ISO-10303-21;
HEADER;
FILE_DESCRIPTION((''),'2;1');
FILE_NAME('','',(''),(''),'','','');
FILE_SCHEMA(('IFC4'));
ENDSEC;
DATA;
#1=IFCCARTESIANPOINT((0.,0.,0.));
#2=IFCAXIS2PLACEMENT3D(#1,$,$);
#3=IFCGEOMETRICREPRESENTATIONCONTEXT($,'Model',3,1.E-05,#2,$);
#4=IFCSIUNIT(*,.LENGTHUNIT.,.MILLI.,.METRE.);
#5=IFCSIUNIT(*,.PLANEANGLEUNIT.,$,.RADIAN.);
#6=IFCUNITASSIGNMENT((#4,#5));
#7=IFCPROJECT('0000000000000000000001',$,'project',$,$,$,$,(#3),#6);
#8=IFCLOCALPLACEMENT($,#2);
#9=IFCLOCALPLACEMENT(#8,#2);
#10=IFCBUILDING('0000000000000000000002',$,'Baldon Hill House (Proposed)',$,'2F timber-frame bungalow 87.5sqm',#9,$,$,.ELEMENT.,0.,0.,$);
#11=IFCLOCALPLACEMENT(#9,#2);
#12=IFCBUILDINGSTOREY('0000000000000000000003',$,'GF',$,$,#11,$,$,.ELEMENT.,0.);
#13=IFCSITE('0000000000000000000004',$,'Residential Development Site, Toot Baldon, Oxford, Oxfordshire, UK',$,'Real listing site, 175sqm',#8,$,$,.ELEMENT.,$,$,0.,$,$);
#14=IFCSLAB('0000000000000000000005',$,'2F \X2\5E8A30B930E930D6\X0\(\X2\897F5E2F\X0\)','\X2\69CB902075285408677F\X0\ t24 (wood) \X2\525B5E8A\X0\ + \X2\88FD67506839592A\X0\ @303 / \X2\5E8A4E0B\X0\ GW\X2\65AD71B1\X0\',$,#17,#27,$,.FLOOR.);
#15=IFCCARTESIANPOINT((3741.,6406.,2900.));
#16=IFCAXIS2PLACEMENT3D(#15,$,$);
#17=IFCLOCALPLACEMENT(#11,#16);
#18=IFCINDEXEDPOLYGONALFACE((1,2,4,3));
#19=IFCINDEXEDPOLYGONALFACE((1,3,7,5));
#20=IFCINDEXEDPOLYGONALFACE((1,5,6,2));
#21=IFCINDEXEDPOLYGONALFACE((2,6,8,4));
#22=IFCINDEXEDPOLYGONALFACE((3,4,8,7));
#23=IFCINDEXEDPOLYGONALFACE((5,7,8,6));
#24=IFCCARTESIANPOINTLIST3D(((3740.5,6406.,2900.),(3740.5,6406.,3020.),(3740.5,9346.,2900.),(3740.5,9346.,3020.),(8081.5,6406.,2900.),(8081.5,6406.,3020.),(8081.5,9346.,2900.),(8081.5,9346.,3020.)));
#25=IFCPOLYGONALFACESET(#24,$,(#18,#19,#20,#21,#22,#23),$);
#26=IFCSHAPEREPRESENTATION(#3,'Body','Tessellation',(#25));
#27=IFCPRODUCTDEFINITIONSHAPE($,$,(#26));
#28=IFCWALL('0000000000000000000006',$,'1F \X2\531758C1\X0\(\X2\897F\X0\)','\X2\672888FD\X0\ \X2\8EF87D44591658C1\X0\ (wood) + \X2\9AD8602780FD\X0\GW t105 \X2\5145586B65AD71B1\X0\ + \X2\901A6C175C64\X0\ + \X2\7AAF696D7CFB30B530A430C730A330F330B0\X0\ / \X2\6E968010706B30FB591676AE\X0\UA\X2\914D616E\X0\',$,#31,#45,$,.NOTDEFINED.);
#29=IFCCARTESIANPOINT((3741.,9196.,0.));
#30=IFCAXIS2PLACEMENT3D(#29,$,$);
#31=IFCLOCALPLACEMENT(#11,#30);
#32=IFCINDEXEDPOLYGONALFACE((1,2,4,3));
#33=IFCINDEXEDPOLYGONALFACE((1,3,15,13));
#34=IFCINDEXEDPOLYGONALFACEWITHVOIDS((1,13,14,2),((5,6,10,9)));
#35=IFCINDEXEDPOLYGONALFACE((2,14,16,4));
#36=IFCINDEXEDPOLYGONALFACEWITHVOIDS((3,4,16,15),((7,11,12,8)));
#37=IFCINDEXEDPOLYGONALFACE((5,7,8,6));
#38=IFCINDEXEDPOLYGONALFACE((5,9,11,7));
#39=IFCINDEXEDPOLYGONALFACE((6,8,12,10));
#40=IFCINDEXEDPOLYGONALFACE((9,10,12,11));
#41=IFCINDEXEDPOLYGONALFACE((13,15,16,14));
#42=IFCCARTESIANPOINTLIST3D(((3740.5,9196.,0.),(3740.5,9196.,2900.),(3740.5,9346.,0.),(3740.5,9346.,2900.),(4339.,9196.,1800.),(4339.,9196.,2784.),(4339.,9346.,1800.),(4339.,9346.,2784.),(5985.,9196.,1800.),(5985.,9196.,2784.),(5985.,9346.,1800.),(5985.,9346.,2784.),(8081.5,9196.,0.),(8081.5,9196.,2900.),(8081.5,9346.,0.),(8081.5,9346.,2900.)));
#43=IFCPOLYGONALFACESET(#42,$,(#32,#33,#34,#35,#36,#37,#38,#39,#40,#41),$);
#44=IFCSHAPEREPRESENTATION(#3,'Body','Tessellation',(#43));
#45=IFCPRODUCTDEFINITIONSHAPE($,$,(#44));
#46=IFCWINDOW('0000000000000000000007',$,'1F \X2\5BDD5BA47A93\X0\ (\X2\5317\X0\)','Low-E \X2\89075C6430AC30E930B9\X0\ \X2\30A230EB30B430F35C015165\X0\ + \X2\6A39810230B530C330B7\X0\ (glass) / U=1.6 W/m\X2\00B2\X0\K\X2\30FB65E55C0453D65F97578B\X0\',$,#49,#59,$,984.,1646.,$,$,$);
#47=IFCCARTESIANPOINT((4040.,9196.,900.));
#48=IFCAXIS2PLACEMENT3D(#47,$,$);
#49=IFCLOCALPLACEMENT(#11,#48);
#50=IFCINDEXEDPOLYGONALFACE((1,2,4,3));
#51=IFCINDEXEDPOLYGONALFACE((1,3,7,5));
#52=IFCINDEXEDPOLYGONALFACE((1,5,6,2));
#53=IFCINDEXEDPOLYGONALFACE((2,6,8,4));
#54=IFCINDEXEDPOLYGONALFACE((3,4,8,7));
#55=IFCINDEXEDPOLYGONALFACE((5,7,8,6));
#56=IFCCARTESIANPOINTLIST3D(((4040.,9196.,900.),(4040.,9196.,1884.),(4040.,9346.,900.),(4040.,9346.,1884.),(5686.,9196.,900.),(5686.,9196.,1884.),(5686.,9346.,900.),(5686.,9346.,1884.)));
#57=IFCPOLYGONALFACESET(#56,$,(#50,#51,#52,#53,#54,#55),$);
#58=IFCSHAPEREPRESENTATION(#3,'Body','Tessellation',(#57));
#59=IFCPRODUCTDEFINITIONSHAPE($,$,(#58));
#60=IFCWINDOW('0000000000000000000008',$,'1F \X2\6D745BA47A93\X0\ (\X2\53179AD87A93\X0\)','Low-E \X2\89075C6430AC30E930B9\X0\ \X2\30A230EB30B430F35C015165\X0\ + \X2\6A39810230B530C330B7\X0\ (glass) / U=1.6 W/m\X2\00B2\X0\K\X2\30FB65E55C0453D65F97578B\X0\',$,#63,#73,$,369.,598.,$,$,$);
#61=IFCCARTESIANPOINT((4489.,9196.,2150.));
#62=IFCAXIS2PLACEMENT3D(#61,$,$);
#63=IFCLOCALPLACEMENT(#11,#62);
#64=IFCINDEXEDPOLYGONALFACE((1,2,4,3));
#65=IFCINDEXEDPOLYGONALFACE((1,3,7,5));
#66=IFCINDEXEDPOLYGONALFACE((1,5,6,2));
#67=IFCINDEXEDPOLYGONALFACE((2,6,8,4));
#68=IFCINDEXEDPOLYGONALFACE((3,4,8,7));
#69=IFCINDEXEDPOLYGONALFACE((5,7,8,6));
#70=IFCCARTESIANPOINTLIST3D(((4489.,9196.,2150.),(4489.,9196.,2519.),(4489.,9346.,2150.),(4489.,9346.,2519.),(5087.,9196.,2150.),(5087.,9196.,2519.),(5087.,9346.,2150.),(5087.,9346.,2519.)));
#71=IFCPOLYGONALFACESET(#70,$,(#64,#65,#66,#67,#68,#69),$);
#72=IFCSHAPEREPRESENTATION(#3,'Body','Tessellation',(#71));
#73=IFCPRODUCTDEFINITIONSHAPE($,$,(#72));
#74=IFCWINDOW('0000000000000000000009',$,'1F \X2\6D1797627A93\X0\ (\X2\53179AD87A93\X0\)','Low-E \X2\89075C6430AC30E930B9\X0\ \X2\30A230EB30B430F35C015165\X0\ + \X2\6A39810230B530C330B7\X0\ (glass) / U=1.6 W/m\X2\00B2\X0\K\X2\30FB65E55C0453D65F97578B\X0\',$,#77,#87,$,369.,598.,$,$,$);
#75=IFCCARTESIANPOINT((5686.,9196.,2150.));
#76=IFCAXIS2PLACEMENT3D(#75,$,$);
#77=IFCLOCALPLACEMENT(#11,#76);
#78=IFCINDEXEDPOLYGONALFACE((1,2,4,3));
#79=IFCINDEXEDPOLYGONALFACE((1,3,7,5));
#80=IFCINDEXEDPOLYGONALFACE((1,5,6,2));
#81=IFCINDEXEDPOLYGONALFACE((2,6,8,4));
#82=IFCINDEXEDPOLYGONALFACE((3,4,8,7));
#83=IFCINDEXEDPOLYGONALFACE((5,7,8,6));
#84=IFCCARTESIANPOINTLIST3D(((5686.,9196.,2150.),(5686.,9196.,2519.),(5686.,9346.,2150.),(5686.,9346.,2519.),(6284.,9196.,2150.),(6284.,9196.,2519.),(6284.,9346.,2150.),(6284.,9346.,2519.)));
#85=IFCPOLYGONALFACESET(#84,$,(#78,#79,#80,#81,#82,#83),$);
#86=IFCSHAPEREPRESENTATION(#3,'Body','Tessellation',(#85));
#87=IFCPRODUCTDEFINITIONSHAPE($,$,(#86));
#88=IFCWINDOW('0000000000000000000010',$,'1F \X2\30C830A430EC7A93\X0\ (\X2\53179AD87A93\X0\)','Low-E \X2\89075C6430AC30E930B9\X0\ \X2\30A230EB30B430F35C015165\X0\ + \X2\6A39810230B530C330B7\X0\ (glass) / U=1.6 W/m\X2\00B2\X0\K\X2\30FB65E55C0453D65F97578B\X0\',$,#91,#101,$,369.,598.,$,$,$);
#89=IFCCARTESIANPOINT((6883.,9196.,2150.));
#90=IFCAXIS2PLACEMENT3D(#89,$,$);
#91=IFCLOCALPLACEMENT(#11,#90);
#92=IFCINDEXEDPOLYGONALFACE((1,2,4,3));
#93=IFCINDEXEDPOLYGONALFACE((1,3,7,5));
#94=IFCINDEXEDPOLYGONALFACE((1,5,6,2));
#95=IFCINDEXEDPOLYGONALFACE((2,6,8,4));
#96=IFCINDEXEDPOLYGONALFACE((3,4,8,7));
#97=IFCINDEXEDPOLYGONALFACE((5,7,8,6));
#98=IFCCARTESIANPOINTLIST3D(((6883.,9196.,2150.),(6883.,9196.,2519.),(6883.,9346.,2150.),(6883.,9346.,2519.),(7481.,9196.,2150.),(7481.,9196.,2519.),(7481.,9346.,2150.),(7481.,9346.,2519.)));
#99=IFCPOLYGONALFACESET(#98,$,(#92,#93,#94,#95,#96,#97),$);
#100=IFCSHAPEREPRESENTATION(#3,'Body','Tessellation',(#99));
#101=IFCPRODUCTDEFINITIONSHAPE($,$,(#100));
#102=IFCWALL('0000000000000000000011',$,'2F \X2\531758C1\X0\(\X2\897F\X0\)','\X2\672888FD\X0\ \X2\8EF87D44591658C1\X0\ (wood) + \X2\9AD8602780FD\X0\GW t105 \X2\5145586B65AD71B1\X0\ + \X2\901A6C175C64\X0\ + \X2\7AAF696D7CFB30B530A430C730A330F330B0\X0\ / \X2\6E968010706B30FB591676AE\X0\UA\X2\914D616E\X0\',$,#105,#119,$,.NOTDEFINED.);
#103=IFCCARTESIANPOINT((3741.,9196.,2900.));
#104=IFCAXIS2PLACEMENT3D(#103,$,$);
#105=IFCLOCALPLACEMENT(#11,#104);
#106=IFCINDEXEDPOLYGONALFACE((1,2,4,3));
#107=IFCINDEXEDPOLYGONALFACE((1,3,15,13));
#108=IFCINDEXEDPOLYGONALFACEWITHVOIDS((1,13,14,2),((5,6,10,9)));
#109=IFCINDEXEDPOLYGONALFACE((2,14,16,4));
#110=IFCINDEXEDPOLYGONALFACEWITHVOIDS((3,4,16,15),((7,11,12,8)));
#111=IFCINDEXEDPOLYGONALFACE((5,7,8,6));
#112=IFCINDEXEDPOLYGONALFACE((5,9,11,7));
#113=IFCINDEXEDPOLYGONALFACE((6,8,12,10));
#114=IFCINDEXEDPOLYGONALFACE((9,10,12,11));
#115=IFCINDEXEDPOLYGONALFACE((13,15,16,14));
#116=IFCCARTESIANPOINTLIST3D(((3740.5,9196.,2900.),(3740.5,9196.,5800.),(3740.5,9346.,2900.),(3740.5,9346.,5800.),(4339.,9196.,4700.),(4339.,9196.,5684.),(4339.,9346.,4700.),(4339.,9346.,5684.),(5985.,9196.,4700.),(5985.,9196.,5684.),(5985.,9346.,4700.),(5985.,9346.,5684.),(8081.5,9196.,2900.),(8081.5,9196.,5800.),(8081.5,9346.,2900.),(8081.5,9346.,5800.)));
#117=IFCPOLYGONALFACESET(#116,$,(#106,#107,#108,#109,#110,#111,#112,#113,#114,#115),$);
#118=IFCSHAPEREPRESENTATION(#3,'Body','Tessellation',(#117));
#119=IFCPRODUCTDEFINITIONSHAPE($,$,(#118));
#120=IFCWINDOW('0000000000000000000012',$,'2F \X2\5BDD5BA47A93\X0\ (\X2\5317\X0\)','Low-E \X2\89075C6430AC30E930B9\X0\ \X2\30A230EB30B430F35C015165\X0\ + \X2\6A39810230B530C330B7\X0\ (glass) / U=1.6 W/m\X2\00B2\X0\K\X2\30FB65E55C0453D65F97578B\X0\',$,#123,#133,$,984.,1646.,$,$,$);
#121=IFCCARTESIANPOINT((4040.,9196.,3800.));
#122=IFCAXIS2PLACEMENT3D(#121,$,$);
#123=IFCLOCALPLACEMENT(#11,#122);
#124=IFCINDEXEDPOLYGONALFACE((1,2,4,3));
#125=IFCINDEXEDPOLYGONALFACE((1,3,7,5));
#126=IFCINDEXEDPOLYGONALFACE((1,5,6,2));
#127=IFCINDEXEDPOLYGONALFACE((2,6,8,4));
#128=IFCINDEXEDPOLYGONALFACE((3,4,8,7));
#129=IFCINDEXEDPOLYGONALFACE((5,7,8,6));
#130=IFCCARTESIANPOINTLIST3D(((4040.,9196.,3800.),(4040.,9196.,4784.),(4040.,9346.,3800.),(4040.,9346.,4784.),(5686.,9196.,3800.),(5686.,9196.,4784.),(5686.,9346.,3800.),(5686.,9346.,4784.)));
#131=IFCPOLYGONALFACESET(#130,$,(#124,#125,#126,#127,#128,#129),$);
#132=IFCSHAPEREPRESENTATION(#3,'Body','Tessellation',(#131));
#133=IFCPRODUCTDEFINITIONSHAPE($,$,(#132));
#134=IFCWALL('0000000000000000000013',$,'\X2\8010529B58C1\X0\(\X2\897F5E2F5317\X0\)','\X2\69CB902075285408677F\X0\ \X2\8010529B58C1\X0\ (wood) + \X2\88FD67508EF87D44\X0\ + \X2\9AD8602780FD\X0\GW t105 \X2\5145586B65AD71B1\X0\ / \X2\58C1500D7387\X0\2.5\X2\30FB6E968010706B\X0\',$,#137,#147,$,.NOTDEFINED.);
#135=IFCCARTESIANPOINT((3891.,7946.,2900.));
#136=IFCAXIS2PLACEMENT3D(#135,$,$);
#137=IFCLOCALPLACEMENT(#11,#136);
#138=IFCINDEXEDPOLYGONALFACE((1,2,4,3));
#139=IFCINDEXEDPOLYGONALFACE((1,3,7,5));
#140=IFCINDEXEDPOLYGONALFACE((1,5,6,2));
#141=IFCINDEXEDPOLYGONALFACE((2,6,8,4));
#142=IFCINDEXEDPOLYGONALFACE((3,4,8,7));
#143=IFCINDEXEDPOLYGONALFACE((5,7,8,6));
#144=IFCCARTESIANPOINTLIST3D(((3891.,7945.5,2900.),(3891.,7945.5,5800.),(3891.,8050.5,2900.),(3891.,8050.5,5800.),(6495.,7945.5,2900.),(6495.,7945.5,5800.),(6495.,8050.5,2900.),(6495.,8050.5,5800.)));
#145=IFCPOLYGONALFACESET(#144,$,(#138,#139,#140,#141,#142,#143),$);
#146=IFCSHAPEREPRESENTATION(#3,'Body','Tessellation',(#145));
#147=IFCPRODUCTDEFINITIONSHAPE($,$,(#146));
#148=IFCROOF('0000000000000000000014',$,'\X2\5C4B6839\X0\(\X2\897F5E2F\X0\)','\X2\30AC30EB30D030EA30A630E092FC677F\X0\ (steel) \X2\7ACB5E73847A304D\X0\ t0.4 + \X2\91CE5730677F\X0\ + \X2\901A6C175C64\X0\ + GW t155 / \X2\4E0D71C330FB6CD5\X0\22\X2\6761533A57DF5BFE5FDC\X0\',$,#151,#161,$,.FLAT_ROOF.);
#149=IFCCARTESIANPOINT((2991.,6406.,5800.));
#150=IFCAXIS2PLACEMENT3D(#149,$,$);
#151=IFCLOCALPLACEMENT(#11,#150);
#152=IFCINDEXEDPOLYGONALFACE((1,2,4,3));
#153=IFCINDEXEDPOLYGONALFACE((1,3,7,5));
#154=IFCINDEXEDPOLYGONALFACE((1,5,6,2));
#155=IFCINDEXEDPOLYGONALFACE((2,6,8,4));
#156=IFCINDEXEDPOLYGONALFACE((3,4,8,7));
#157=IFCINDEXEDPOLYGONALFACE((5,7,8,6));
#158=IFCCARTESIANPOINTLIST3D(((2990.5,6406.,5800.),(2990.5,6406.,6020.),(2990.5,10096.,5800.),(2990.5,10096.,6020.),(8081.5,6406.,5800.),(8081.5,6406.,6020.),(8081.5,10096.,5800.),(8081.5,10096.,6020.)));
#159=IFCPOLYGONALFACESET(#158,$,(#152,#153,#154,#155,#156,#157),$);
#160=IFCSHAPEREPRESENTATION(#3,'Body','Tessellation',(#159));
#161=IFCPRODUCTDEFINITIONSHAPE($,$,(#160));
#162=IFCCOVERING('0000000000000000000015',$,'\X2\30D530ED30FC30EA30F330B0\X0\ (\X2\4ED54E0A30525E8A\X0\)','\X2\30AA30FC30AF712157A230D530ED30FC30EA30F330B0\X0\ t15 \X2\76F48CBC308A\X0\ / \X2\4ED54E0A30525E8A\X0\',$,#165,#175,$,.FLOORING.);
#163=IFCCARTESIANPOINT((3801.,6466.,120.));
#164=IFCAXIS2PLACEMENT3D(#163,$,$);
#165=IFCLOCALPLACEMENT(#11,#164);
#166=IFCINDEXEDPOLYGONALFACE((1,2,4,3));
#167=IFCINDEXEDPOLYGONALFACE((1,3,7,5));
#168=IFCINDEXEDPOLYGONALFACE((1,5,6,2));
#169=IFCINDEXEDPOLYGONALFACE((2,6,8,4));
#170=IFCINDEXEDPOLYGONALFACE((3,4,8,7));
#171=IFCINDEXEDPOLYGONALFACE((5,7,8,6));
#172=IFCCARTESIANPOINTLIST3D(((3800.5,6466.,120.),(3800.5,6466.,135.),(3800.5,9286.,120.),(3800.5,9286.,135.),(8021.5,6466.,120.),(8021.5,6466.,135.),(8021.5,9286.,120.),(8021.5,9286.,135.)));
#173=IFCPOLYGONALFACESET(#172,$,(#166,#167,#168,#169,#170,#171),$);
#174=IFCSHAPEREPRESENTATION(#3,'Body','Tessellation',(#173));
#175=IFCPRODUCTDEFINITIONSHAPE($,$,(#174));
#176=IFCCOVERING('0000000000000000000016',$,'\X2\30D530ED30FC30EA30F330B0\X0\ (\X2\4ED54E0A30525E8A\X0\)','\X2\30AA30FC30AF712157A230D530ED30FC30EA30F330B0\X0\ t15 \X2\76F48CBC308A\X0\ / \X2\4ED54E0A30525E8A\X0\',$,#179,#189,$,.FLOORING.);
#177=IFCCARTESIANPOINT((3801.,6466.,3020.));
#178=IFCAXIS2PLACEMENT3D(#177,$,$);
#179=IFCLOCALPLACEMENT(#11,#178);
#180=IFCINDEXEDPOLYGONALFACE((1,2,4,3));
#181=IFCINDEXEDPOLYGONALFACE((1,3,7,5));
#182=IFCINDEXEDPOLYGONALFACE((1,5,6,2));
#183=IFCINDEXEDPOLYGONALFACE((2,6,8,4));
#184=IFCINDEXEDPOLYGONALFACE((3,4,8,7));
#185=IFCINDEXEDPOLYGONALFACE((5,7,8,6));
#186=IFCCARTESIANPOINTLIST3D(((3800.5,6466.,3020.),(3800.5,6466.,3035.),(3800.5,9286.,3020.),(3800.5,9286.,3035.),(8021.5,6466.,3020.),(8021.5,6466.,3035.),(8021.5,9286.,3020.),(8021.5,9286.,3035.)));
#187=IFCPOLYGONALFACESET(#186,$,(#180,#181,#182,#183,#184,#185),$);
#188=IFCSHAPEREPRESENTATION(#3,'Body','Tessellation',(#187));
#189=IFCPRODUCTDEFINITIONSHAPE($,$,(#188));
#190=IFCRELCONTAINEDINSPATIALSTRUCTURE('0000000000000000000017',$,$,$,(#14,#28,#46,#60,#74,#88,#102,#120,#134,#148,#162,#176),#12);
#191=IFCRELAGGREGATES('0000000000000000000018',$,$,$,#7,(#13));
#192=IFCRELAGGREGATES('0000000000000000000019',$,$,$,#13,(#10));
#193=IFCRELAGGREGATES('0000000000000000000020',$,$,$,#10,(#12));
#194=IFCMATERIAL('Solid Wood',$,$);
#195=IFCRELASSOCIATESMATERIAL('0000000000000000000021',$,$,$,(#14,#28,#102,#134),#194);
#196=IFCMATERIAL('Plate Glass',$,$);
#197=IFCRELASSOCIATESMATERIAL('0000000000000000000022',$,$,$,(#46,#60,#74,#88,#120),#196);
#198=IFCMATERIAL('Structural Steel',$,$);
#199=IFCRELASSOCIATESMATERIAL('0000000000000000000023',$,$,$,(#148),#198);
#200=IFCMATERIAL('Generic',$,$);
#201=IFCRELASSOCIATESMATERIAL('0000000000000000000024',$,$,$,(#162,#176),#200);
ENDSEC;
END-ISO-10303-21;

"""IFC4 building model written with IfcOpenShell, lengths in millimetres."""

from ifc_helpers import new_model, si_unit, frame, frame_2d, origin, place, context, project, spatial, rectangle, extrude, material, element, fill, save


model = new_model("IFC4")

# Units and contexts
model_context = context("Model", 3, precision=1e-05, world=origin())
ifc_project = project(units=[si_unit("LENGTHUNIT", "METRE", prefix="MILLI"), si_unit("PLANEANGLEUNIT", "RADIAN")], contexts=[model_context])

# Site, building, storey
site_placement = place(None, origin())
site = spatial("IfcSite", under=ifc_project, at=site_placement, Name="Residential Development Site, Toot Baldon, Oxford, Oxfordshire, UK", ObjectType="Real listing site, 175sqm", CompositionType="ELEMENT", RefElevation=0.0)
building_placement = place(site_placement, origin())
building = spatial("IfcBuilding", under=site, at=building_placement, Name="Baldon Hill House (Proposed)", ObjectType="2F timber-frame bungalow 87.5sqm", CompositionType="ELEMENT", ElevationOfRefHeight=0.0, ElevationOfTerrain=0.0)
storey_placement = place(building_placement, origin())
storey = spatial("IfcBuildingStorey", under=building, at=storey_placement, Name="GF", CompositionType="ELEMENT", Elevation=0.0)

# Slab
ifc_material_1 = material(Name="Solid Wood")
slab_1_placement = place(storey_placement, frame((3741.0, 6406.0, 2900.0)))
element("IfcSlab", 1, at=slab_1_placement, inside=storey, material=ifc_material_1, Name="2F 床スラブ(西帯)", Description="構造用合板 t24 (wood) 剛床 + 製材根太 @303 / 床下 GW断熱", PredefinedType="FLOOR", context=model_context, shape_type="SweptSolid", body=[
    extrude(rectangle(XDim=4341.0, YDim=2940.0, at=frame_2d((2170.0, 1470.0))), frame((3741.0, 6406.0, 2900.0)), (0.0, 0.0, 1.0), 120.0),
])

# Wall, openings, windows
wall_1_placement = place(storey_placement, frame((3741.0, 9196.0, 0.0)))
wall_1 = element("IfcWall", 2, at=wall_1_placement, inside=storey, material=ifc_material_1, Name="1F 北壁(西)", Description="木製 軸組外壁 (wood) + 高性能GW t105 充填断熱 + 通気層 + 窯業系サイディング / 準耐火・外皮UA配慮", PredefinedType="NOTDEFINED", context=model_context, shape_type="SweptSolid", body=[
    extrude(rectangle(XDim=4341.0, YDim=150.0, at=frame_2d((2170.0, 75.0))), frame((3741.0, 9196.0, 0.0)), (0.0, 0.0, 1.0), 2900.0),
])
opening_1_placement = place(storey_placement, frame((4040.0, 9196.0, 900.0)))
opening_1 = element("IfcOpeningElement", 3, at=opening_1_placement, cuts=wall_1, PredefinedType="NOTDEFINED", context=model_context, shape_type="SweptSolid", body=[
    extrude(rectangle(XDim=1646.0, YDim=150.0, at=frame_2d((823.0, 75.0))), frame((4040.0, 9196.0, 900.0)), (0.0, 0.0, 1.0), 984.0),
])
opening_2_placement = place(storey_placement, frame((4489.0, 9196.0, 2150.0)))
opening_2 = element("IfcOpeningElement", 4, at=opening_2_placement, cuts=wall_1, PredefinedType="NOTDEFINED", context=model_context, shape_type="SweptSolid", body=[
    extrude(rectangle(XDim=598.0, YDim=150.0, at=frame_2d((299.0, 75.0))), frame((4489.0, 9196.0, 2150.0)), (0.0, 0.0, 1.0), 369.0),
])
opening_3_placement = place(storey_placement, frame((5686.0, 9196.0, 2150.0)))
opening_3 = element("IfcOpeningElement", 5, at=opening_3_placement, cuts=wall_1, PredefinedType="NOTDEFINED", context=model_context, shape_type="SweptSolid", body=[
    extrude(rectangle(XDim=598.0, YDim=150.0, at=frame_2d((299.0, 75.0))), frame((5686.0, 9196.0, 2150.0)), (0.0, 0.0, 1.0), 369.0),
])
opening_4_placement = place(storey_placement, frame((6883.0, 9196.0, 2150.0)))
opening_4 = element("IfcOpeningElement", 6, at=opening_4_placement, cuts=wall_1, PredefinedType="NOTDEFINED", context=model_context, shape_type="SweptSolid", body=[
    extrude(rectangle(XDim=598.0, YDim=150.0, at=frame_2d((299.0, 75.0))), frame((6883.0, 9196.0, 2150.0)), (0.0, 0.0, 1.0), 369.0),
])
ifc_material_2 = material(Name="Plate Glass")
window_1_placement = place(storey_placement, frame((4040.0, 9196.0, 900.0)))
window_1 = element("IfcWindow", 7, at=window_1_placement, inside=storey, material=ifc_material_2, Name="1F 寝室窓 (北)", Description="Low-E 複層ガラス アルゴン封入 + 樹脂サッシ (glass) / U=1.6 W/m²K・日射取得型", OverallHeight=984.0, OverallWidth=1646.0, context=model_context, shape_type="SweptSolid", body=[
    extrude(rectangle(XDim=1646.0, YDim=150.0, at=frame_2d((823.0, 75.0))), frame((4040.0, 9196.0, 900.0)), (0.0, 0.0, 1.0), 984.0),
])
fill(opening_1, window_1)
window_2_placement = place(storey_placement, frame((4489.0, 9196.0, 2150.0)))
window_2 = element("IfcWindow", 8, at=window_2_placement, inside=storey, material=ifc_material_2, Name="1F 浴室窓 (北高窓)", Description="Low-E 複層ガラス アルゴン封入 + 樹脂サッシ (glass) / U=1.6 W/m²K・日射取得型", OverallHeight=369.0, OverallWidth=598.0, context=model_context, shape_type="SweptSolid", body=[
    extrude(rectangle(XDim=598.0, YDim=150.0, at=frame_2d((299.0, 75.0))), frame((4489.0, 9196.0, 2150.0)), (0.0, 0.0, 1.0), 369.0),
])
fill(opening_2, window_2)
window_3_placement = place(storey_placement, frame((5686.0, 9196.0, 2150.0)))
window_3 = element("IfcWindow", 9, at=window_3_placement, inside=storey, material=ifc_material_2, Name="1F 洗面窓 (北高窓)", Description="Low-E 複層ガラス アルゴン封入 + 樹脂サッシ (glass) / U=1.6 W/m²K・日射取得型", OverallHeight=369.0, OverallWidth=598.0, context=model_context, shape_type="SweptSolid", body=[
    extrude(rectangle(XDim=598.0, YDim=150.0, at=frame_2d((299.0, 75.0))), frame((5686.0, 9196.0, 2150.0)), (0.0, 0.0, 1.0), 369.0),
])
fill(opening_3, window_3)
window_4_placement = place(storey_placement, frame((6883.0, 9196.0, 2150.0)))
window_4 = element("IfcWindow", 10, at=window_4_placement, inside=storey, material=ifc_material_2, Name="1F トイレ窓 (北高窓)", Description="Low-E 複層ガラス アルゴン封入 + 樹脂サッシ (glass) / U=1.6 W/m²K・日射取得型", OverallHeight=369.0, OverallWidth=598.0, context=model_context, shape_type="SweptSolid", body=[
    extrude(rectangle(XDim=598.0, YDim=150.0, at=frame_2d((299.0, 75.0))), frame((6883.0, 9196.0, 2150.0)), (0.0, 0.0, 1.0), 369.0),
])
fill(opening_4, window_4)

# Wall, opening, window
wall_2_placement = place(storey_placement, frame((3741.0, 9196.0, 2900.0)))
wall_2 = element("IfcWall", 11, at=wall_2_placement, inside=storey, material=ifc_material_1, Name="2F 北壁(西)", Description="木製 軸組外壁 (wood) + 高性能GW t105 充填断熱 + 通気層 + 窯業系サイディング / 準耐火・外皮UA配慮", PredefinedType="NOTDEFINED", context=model_context, shape_type="SweptSolid", body=[
    extrude(rectangle(XDim=4341.0, YDim=150.0, at=frame_2d((2170.0, 75.0))), frame((3741.0, 9196.0, 2900.0)), (0.0, 0.0, 1.0), 2900.0),
])
opening_5_placement = place(storey_placement, frame((4040.0, 9196.0, 3800.0)))
opening_5 = element("IfcOpeningElement", 12, at=opening_5_placement, cuts=wall_2, PredefinedType="NOTDEFINED", context=model_context, shape_type="SweptSolid", body=[
    extrude(rectangle(XDim=1646.0, YDim=150.0, at=frame_2d((823.0, 75.0))), frame((4040.0, 9196.0, 3800.0)), (0.0, 0.0, 1.0), 984.0),
])
window_5_placement = place(storey_placement, frame((4040.0, 9196.0, 3800.0)))
window_5 = element("IfcWindow", 13, at=window_5_placement, inside=storey, material=ifc_material_2, Name="2F 寝室窓 (北)", Description="Low-E 複層ガラス アルゴン封入 + 樹脂サッシ (glass) / U=1.6 W/m²K・日射取得型", OverallHeight=984.0, OverallWidth=1646.0, context=model_context, shape_type="SweptSolid", body=[
    extrude(rectangle(XDim=1646.0, YDim=150.0, at=frame_2d((823.0, 75.0))), frame((4040.0, 9196.0, 3800.0)), (0.0, 0.0, 1.0), 984.0),
])
fill(opening_5, window_5)

# Wall
wall_3_placement = place(storey_placement, frame((3891.0, 7946.0, 2900.0)))
element("IfcWall", 14, at=wall_3_placement, inside=storey, material=ifc_material_1, Name="耐力壁(西帯北)", Description="構造用合板 耐力壁 (wood) + 製材軸組 + 高性能GW t105 充填断熱 / 壁倍率2.5・準耐火", PredefinedType="NOTDEFINED", context=model_context, shape_type="SweptSolid", body=[
    extrude(rectangle(XDim=2604.0, YDim=105.0, at=frame_2d((1302.0, 52.0))), frame((3891.0, 7946.0, 2900.0)), (0.0, 0.0, 1.0), 2900.0),
])

# Roof
ifc_material_3 = material(Name="Structural Steel")
for number, where, name in (
    (15, (2991.0, 6406.0, 5800.0), "屋根(西帯)"),
):
    element("IfcRoof", number, at=place(storey_placement, frame(where)), inside=storey, material=ifc_material_3, Name=name, Description="ガルバリウム鋼板 (steel) 立平葺き t0.4 + 野地板 + 通気層 + GW t155 / 不燃・法22条区域対応", PredefinedType="FLAT_ROOF", context=model_context, shape_type="SweptSolid", body=[
        extrude(rectangle(XDim=5091.0, YDim=3690.0, at=frame_2d((2545.0, 1845.0))), frame((2991.0, 6406.0, 5800.0)), (0.0, 0.0, 1.0), 220.0),
    ])

# Coverings
ifc_material_4 = material(Name="Generic")
covering_1_placement = place(storey_placement, frame((3801.0, 6466.0, 120.0)))
element("IfcCovering", 16, at=covering_1_placement, inside=storey, material=ifc_material_4, Name="フローリング (仕上げ床)", Description="オーク無垢フローリング t15 直貼り / 仕上げ床", PredefinedType="FLOORING", context=model_context, shape_type="SweptSolid", body=[
    extrude(rectangle(XDim=4221.0, YDim=2820.0, at=frame_2d((2110.0, 1410.0))), frame((3801.0, 6466.0, 120.0)), (0.0, 0.0, 1.0), 15.0),
])
covering_2_placement = place(storey_placement, frame((3801.0, 6466.0, 3020.0)))
element("IfcCovering", 17, at=covering_2_placement, inside=storey, material=ifc_material_4, Name="フローリング (仕上げ床)", Description="オーク無垢フローリング t15 直貼り / 仕上げ床", PredefinedType="FLOORING", context=model_context, shape_type="SweptSolid", body=[
    extrude(rectangle(XDim=4221.0, YDim=2820.0, at=frame_2d((2110.0, 1410.0))), frame((3801.0, 6466.0, 3020.0)), (0.0, 0.0, 1.0), 15.0),
])

save(model, "model.ifc")
